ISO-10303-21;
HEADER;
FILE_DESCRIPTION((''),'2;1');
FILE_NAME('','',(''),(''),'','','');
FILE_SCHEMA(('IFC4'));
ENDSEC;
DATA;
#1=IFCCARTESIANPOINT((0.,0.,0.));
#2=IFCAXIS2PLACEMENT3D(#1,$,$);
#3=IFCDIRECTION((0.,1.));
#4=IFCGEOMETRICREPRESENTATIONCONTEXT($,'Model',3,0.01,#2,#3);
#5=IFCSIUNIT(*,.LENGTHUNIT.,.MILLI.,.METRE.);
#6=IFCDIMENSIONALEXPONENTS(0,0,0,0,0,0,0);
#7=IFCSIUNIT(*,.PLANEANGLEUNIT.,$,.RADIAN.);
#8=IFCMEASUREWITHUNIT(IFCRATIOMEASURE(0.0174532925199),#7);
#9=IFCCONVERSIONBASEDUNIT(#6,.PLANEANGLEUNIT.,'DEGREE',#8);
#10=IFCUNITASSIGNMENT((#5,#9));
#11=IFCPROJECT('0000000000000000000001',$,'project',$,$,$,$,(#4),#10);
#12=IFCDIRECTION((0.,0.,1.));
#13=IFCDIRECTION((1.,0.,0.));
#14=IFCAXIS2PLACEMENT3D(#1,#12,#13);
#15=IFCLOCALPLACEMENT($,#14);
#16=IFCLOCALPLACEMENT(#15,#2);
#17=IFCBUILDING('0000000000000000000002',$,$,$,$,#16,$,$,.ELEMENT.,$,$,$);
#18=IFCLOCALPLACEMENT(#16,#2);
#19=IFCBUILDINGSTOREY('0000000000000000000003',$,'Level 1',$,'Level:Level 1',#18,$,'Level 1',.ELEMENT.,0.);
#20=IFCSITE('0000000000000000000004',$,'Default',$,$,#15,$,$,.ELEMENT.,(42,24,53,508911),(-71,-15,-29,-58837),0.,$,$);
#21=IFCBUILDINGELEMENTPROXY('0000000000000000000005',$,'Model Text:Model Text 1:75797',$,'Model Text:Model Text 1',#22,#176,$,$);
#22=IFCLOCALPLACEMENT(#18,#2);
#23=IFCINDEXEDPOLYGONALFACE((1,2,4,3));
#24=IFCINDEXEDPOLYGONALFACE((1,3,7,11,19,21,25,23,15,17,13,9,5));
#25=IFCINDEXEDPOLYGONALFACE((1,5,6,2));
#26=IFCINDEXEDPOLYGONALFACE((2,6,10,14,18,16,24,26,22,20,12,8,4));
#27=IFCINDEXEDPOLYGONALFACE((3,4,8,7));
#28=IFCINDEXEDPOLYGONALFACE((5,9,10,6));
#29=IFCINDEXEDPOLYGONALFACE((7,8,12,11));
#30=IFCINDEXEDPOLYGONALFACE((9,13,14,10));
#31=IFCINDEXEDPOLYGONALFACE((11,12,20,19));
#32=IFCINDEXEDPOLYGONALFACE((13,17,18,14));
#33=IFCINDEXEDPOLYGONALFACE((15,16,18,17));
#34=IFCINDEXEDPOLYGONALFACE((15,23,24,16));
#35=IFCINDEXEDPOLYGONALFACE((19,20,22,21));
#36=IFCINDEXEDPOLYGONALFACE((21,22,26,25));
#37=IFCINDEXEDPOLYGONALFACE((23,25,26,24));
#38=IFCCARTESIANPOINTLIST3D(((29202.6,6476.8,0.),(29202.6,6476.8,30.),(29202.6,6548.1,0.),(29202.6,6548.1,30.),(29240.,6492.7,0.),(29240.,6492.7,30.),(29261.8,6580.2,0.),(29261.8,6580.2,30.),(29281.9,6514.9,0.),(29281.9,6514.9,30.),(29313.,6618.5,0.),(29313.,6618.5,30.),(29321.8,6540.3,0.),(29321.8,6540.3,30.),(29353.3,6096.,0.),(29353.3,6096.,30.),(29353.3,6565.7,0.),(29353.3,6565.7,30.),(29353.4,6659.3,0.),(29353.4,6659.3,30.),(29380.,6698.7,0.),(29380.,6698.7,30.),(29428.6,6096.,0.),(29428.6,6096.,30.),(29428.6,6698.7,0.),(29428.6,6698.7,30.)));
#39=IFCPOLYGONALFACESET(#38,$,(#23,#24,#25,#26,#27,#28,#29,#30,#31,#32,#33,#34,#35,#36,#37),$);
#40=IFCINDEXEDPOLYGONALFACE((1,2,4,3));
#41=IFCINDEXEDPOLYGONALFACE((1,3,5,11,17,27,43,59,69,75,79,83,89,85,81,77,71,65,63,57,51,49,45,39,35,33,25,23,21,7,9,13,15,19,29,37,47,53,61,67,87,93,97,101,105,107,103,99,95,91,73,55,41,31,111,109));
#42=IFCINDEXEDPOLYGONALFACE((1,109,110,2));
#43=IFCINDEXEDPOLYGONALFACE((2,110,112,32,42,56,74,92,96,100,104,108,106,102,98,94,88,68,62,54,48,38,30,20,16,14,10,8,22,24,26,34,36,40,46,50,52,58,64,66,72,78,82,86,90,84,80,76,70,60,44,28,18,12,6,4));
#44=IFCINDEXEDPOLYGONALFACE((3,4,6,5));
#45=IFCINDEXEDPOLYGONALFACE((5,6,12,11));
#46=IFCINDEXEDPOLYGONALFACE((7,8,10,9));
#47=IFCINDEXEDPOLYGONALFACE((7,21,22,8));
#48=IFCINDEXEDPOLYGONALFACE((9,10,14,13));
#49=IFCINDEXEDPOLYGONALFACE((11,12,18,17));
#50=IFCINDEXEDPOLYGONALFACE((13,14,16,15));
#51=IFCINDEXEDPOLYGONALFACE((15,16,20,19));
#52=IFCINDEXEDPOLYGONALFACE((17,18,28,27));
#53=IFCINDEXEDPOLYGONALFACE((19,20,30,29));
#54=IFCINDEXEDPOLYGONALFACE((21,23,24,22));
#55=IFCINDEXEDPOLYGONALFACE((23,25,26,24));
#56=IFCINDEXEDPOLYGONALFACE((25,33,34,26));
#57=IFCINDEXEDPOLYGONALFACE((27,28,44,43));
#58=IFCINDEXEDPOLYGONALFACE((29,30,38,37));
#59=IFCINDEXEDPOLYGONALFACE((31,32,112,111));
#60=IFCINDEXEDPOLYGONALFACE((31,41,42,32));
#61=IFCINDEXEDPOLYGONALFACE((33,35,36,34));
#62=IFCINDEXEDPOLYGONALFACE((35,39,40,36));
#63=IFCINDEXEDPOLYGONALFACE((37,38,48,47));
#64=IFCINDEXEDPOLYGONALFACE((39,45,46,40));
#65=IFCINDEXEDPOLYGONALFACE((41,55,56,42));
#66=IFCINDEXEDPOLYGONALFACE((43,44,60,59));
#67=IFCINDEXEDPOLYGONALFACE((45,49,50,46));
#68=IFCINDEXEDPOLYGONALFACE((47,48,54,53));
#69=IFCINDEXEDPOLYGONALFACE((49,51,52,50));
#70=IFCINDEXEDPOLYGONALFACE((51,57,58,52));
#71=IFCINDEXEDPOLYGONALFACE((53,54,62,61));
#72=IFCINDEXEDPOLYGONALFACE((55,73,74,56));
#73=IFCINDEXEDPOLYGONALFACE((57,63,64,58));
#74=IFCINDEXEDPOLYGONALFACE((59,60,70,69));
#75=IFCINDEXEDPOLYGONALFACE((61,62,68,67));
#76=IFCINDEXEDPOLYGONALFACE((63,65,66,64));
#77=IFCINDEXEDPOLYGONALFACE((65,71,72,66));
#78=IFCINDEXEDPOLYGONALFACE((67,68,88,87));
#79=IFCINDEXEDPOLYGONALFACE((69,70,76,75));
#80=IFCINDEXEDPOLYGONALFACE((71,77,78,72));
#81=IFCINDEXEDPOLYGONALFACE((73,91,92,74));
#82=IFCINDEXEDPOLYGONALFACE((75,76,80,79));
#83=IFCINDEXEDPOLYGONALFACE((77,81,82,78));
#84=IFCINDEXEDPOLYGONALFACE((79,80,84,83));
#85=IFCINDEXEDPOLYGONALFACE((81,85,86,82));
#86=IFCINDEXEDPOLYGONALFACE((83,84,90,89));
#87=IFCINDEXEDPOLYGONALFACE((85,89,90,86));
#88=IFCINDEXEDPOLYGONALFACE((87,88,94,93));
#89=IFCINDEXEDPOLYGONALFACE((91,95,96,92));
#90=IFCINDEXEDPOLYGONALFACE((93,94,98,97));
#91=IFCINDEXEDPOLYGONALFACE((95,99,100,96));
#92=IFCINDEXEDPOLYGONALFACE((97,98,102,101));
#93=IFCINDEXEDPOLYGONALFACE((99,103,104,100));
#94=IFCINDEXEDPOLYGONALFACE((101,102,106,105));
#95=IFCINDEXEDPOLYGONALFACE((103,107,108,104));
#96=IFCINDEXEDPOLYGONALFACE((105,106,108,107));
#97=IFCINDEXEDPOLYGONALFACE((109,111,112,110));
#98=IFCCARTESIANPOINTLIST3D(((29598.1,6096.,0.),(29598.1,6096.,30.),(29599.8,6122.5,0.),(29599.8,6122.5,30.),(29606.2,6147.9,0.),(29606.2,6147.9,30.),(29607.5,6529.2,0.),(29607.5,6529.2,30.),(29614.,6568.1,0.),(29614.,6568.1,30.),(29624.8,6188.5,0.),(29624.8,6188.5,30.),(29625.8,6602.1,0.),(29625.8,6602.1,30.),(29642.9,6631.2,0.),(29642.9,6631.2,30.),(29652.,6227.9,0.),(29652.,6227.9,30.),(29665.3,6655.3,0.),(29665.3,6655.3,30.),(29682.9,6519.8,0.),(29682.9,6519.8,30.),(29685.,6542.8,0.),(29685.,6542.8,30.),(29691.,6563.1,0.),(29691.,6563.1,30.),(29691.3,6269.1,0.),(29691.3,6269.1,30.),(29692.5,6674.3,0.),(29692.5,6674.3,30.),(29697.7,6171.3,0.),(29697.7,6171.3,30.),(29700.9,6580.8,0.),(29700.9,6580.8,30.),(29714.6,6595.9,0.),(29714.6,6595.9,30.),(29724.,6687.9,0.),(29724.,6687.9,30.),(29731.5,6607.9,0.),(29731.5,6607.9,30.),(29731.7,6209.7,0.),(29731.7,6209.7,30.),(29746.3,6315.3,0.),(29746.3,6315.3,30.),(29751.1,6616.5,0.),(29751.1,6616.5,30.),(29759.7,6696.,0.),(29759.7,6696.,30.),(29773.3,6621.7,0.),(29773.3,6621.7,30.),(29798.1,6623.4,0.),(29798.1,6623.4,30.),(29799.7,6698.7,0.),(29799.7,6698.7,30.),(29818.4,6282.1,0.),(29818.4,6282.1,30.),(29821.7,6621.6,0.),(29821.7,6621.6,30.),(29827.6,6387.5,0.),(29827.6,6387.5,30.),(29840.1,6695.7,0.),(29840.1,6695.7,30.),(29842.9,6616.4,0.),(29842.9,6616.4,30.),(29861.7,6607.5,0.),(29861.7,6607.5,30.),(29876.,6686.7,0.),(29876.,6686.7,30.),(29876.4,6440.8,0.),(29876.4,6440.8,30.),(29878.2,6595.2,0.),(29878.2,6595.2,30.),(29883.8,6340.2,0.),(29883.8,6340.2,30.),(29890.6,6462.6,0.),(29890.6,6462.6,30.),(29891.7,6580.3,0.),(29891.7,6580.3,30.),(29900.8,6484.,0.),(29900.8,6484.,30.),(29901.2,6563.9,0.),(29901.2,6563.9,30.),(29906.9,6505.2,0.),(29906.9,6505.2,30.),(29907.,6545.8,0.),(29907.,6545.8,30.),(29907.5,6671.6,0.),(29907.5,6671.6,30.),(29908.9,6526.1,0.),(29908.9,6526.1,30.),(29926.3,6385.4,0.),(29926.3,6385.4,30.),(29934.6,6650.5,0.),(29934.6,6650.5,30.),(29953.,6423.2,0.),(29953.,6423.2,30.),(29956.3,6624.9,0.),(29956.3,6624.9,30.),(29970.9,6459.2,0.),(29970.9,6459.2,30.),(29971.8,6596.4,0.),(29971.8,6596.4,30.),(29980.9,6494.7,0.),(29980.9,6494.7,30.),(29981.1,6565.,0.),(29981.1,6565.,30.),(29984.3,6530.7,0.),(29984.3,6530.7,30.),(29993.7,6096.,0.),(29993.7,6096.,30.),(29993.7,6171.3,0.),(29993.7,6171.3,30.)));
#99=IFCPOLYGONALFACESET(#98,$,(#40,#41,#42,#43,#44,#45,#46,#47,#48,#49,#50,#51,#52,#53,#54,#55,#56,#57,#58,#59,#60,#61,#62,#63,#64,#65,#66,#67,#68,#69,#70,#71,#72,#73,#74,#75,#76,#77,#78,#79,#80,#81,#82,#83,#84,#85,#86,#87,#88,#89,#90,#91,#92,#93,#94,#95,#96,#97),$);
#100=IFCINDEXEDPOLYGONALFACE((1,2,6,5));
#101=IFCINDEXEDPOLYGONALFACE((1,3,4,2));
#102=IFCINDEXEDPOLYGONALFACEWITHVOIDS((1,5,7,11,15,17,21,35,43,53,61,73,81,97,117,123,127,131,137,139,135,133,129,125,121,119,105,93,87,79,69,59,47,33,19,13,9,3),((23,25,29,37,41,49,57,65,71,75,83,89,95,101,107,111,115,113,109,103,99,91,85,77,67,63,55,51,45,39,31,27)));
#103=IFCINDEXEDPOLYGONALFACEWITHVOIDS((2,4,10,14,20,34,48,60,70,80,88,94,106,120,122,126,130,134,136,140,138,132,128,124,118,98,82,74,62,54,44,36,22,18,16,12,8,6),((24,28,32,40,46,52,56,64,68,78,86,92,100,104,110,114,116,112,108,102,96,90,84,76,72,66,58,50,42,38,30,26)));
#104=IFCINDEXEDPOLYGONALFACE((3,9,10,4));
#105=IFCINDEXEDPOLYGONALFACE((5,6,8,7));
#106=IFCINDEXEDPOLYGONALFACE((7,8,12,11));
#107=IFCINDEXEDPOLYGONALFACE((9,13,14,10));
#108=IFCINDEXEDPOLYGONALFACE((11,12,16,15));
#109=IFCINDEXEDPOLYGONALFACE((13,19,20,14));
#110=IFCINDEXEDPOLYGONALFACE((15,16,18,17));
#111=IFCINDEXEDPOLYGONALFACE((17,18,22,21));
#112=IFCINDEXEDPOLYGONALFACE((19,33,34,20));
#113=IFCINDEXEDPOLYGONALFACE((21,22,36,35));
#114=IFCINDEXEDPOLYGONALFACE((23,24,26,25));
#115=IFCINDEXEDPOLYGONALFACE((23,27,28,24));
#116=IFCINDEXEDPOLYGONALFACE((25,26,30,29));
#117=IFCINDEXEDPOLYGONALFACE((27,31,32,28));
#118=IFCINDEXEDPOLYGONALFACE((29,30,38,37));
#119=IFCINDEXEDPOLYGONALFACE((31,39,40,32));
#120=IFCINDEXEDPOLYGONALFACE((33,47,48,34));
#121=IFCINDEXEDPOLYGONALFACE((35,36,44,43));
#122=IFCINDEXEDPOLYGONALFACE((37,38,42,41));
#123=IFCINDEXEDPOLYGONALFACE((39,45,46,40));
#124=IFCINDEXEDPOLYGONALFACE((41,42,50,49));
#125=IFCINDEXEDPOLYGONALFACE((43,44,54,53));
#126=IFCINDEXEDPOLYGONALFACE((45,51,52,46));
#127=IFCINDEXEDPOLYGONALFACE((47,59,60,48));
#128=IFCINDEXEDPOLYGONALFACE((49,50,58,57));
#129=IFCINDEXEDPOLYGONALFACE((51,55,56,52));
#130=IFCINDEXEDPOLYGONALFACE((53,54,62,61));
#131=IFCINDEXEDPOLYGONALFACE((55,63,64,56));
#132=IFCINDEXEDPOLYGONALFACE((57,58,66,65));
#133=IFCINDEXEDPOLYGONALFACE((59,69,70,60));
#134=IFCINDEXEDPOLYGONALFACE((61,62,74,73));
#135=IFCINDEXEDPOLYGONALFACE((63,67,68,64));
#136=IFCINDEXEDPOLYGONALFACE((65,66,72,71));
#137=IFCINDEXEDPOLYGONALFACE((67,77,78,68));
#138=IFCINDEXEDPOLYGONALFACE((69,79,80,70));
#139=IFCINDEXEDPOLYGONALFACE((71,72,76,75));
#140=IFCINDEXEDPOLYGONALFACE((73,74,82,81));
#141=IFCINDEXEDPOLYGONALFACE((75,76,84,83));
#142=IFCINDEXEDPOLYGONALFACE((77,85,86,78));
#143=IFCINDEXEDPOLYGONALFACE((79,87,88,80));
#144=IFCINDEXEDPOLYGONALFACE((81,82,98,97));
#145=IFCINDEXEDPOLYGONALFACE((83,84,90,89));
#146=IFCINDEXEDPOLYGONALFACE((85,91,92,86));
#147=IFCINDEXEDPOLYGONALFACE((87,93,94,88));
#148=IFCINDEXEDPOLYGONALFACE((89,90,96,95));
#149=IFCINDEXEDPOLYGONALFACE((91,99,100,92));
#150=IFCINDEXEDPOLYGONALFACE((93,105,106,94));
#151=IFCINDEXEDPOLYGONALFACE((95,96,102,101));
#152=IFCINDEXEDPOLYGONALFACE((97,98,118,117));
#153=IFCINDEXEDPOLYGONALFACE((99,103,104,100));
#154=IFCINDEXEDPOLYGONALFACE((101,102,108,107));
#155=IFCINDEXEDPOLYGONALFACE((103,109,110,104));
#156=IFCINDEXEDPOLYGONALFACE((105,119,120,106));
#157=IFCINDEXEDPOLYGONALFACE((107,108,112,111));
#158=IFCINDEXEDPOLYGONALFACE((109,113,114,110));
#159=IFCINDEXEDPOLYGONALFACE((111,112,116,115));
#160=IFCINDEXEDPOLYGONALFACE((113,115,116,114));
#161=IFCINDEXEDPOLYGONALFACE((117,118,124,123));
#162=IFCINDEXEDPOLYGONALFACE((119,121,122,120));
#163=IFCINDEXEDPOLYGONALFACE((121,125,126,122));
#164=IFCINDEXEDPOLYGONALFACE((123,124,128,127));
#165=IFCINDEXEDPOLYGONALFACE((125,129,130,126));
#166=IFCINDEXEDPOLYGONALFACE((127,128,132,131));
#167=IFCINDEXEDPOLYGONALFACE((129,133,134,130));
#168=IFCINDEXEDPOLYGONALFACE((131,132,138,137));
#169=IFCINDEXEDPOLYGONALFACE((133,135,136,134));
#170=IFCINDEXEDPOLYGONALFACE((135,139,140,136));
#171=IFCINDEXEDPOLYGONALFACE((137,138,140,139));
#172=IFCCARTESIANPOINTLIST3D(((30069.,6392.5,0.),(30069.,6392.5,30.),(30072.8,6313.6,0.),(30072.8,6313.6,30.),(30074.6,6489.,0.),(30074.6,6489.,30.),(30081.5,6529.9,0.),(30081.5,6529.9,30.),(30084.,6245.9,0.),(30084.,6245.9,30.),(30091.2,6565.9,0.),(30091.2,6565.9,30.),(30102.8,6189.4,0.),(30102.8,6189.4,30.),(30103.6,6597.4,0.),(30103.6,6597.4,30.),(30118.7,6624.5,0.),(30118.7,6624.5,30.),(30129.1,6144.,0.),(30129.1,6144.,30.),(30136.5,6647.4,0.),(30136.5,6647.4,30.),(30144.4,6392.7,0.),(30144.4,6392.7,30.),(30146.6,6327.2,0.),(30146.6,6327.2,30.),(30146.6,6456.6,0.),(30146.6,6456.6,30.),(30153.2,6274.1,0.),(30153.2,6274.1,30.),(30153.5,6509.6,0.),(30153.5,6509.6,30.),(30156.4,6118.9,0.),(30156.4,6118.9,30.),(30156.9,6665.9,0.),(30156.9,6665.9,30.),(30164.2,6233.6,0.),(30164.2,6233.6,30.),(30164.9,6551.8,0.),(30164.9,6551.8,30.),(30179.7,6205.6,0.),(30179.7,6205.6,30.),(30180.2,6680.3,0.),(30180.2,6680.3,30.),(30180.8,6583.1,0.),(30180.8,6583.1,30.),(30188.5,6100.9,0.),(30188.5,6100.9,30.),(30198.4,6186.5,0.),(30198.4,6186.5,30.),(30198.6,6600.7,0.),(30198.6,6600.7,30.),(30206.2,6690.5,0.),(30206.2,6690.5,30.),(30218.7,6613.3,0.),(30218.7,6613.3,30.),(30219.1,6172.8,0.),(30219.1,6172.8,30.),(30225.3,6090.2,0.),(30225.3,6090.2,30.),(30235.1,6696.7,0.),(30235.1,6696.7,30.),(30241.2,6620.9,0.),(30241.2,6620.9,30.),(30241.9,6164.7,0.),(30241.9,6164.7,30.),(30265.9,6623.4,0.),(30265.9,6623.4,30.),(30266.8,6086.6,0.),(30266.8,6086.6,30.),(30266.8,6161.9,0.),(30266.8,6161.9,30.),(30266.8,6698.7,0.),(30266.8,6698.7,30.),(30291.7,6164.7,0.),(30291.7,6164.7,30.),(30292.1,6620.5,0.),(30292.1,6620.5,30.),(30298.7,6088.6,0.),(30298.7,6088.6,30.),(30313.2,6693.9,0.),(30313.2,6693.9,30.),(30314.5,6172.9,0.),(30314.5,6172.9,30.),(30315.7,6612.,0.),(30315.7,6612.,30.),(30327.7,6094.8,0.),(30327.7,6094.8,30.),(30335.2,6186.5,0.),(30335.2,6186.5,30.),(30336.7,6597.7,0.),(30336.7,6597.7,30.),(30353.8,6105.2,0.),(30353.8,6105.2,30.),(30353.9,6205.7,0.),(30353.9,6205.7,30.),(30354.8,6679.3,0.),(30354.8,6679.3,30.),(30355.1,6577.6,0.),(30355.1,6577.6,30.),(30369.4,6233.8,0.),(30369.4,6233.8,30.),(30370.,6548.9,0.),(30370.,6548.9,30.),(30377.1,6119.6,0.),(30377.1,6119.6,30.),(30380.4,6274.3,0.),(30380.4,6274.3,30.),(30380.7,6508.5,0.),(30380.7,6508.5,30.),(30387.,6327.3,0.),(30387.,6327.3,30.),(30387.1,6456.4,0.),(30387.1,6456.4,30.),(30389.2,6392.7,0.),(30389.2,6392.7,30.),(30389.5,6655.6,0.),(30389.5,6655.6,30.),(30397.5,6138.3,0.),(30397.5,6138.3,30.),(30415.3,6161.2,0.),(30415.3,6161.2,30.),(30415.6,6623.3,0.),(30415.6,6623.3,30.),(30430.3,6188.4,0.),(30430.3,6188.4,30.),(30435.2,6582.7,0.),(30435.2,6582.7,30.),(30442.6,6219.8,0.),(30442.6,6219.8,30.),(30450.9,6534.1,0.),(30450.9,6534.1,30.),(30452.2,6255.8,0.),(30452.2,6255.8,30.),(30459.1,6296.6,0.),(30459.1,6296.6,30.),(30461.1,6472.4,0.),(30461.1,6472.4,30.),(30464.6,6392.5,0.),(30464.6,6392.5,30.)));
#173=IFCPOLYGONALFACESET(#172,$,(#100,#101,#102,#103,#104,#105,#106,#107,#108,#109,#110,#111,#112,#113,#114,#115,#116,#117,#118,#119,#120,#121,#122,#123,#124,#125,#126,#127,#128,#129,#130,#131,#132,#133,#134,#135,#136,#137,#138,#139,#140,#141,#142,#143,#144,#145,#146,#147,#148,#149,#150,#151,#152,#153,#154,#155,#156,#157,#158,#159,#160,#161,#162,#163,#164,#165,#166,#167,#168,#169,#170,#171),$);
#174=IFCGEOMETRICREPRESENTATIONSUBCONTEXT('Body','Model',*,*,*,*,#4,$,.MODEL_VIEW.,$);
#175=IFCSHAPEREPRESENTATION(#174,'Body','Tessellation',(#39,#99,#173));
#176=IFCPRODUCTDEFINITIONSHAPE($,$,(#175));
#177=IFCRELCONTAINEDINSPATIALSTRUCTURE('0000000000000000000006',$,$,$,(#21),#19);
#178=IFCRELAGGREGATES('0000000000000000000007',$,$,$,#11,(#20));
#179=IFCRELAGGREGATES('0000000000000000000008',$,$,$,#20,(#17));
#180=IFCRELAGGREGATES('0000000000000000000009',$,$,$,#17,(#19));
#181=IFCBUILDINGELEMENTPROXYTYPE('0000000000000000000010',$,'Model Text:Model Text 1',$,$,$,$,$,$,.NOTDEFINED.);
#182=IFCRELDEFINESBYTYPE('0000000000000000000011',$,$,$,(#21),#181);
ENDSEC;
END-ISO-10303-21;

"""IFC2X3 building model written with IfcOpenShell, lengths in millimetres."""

from ifc_helpers import new_model, entity, si_unit, converted_unit, direction, frame, origin, origin_with_axes, place, context, subcontext, project, spatial, polyline, outline, extrude, type_object, element, save


model = new_model("IFC2X3")

# Units and contexts
model_context = context("Model", 3, precision=0.01, world=origin(), true_north=direction((0.0, 1.0)))
body_context = subcontext(model_context, "Body", "Model", "MODEL_VIEW")
ifc_project = project(units=[si_unit("LENGTHUNIT", "METRE", prefix="MILLI"), converted_unit("PLANEANGLEUNIT", "DEGREE", entity("IfcRatioMeasure", 0.0174532925199), si_unit("PLANEANGLEUNIT", "RADIAN"), dimensions=[0, 0, 0, 0, 0, 0, 0])], contexts=[model_context])

# Site, building, storey
site_placement = place(None, origin_with_axes())
site = spatial("IfcSite", under=ifc_project, at=site_placement, Name="Default", CompositionType="ELEMENT", RefLatitude=(42, 24, 53, 508911), RefLongitude=(-71, -15, -29, -58837), RefElevation=0.0)
building_placement = place(site_placement, origin())
building = spatial("IfcBuilding", under=site, at=building_placement, CompositionType="ELEMENT")
storey_placement = place(building_placement, origin())
storey = spatial("IfcBuildingStorey", under=building, at=storey_placement, Name="Level 1", ObjectType="Level:Level 1", LongName="Level 1", CompositionType="ELEMENT", Elevation=0.0)

# Building element proxy
building_element_proxy_type_1 = type_object("IfcBuildingElementProxyType", Name="Model Text:Model Text 1", PredefinedType="NOTDEFINED")
proxy_1_placement = place(storey_placement, frame((29202.6, 6086.6, 0.0)))
element("IfcBuildingElementProxy", 1, at=proxy_1_placement, inside=storey, type_object=building_element_proxy_type_1, Name="Model Text:Model Text 1:75797", ObjectType="Model Text:Model Text 1", context=body_context, shape_type="SweptSolid", body=[
    extrude(outline(polyline([(-410.6, -111.6), (192.1, -111.6), (192.1, -63.1), (152.7, -36.4), (111.9, 4.0), (73.6, 55.2), (41.4, 114.4), (-29.8, 114.4), (-13.9, 77.0), (8.3, 35.1), (33.7, -4.8), (59.1, -36.3), (-410.6, -36.3), (-410.6, -111.6)])), frame((114.4, 420.0, 0.0), z_axis=(0.0, 0.0, 1.0), x_axis=(0.0, 1.0, 0.0)), (0.0, 0.0, 1.0), 30.0),
    extrude(outline(polyline([(-190.2, -317.5), (-190.2, -392.8), (205.4, -392.8), (203.7, -366.3), (197.3, -340.9), (178.7, -300.3), (151.5, -260.9), (112.2, -219.7), (57.2, -173.6), (-24.1, -101.3), (-72.9, -48.0), (-87.1, -26.3), (-97.3, -4.8), (-103.4, 16.4), (-105.4, 37.3), (-103.5, 57.0), (-97.7, 75.0), (-88.2, 91.5), (-74.7, 106.4), (-58.2, 118.7), (-39.4, 127.5), (-18.2, 132.8), (5.4, 134.6), (30.2, 132.9), (52.4, 127.7), (72.0, 119.1), (88.9, 107.1), (102.6, 92.0), (112.5, 74.3), (118.5, 54.0), (120.6, 31.0), (196.0, 40.4), (189.5, 79.3), (177.7, 113.3), (160.6, 142.4), (138.2, 166.5), (111.0, 185.5), (79.5, 199.1), (43.8, 207.2), (3.8, 209.9), (-36.6, 206.9), (-72.5, 197.9), (-104.0, 182.8), (-131.1, 161.7), (-152.8, 136.1), (-168.3, 107.6), (-177.6, 76.2), (-180.8, 41.9), (-177.4, 5.8), (-167.4, -29.6), (-149.5, -65.6), (-122.8, -103.4), (-80.3, -148.6), (-14.9, -206.7), (71.8, -279.1), (105.8, -317.5), (-190.2, -317.5)])), frame((600.9, 402.2, 0.0), z_axis=(0.0, 0.0, -1.0), x_axis=(-1.0, 0.0, 0.0)), (0.0, 0.0, -1.0), 30.0),
    extrude(outline(polyline([(-10.6, -198.7), (68.3, -198.7), (136.5, -190.7), (193.9, -174.7), (240.5, -150.6), (266.9, -124.4), (286.3, -93.2), (298.8, -57.0), (304.3, -15.7), (303.8, 16.2), (299.0, 45.5), (289.9, 72.1), (276.6, 96.0), (258.9, 117.3), (236.9, 136.2), (210.4, 152.5), (179.6, 166.3), (144.1, 177.6), (103.7, 186.3), (8.2, 196.4), (-71.8, 196.7), (-134.0, 189.4), (-183.3, 176.1), (-224.7, 158.4), (-258.2, 133.9), (-283.5, 100.3), (-300.1, 59.5), (-307.1, 13.4), (-306.6, -18.4), (-301.8, -47.5), (-292.8, -74.0), (-279.6, -97.9), (-262.0, -119.2), (-240.0, -138.1), (-213.6, -154.5), (-182.8, -168.4), (-147.3, -179.8), (-106.7, -188.6), (-10.6, -198.7)]), holes=[polyline([(-7.2, -123.5), (-71.0, -118.2), (-123.6, -108.8), (-165.2, -95.4), (-195.7, -78.0), (-212.4, -59.4), (-224.1, -38.7), (-230.6, -15.9), (-231.9, 8.9), (-227.8, 35.0), (-218.1, 58.1), (-202.8, 78.4), (-182.0, 95.8), (-152.6, 109.4), (-111.7, 118.1), (-59.4, 122.0), (4.4, 121.1), (69.6, 115.8), (122.2, 106.7), (162.2, 93.7), (189.5, 77.0), (207.7, 57.4), (220.4, 36.0), (227.5, 12.8), (229.1, -12.1), (225.2, -36.8), (215.9, -59.2), (201.3, -79.3), (181.4, -97.1), (152.6, -111.2), (111.6, -120.3), (58.3, -124.4), (-7.2, -123.5)])]), frame((1065.4, 304.7, 0.0), z_axis=(0.0, 0.0, 1.0), x_axis=(0.047515, -0.998871, 0.0)), (0.0, 0.0, 1.0), 30.0),
])

save(model, "model.ifc")
